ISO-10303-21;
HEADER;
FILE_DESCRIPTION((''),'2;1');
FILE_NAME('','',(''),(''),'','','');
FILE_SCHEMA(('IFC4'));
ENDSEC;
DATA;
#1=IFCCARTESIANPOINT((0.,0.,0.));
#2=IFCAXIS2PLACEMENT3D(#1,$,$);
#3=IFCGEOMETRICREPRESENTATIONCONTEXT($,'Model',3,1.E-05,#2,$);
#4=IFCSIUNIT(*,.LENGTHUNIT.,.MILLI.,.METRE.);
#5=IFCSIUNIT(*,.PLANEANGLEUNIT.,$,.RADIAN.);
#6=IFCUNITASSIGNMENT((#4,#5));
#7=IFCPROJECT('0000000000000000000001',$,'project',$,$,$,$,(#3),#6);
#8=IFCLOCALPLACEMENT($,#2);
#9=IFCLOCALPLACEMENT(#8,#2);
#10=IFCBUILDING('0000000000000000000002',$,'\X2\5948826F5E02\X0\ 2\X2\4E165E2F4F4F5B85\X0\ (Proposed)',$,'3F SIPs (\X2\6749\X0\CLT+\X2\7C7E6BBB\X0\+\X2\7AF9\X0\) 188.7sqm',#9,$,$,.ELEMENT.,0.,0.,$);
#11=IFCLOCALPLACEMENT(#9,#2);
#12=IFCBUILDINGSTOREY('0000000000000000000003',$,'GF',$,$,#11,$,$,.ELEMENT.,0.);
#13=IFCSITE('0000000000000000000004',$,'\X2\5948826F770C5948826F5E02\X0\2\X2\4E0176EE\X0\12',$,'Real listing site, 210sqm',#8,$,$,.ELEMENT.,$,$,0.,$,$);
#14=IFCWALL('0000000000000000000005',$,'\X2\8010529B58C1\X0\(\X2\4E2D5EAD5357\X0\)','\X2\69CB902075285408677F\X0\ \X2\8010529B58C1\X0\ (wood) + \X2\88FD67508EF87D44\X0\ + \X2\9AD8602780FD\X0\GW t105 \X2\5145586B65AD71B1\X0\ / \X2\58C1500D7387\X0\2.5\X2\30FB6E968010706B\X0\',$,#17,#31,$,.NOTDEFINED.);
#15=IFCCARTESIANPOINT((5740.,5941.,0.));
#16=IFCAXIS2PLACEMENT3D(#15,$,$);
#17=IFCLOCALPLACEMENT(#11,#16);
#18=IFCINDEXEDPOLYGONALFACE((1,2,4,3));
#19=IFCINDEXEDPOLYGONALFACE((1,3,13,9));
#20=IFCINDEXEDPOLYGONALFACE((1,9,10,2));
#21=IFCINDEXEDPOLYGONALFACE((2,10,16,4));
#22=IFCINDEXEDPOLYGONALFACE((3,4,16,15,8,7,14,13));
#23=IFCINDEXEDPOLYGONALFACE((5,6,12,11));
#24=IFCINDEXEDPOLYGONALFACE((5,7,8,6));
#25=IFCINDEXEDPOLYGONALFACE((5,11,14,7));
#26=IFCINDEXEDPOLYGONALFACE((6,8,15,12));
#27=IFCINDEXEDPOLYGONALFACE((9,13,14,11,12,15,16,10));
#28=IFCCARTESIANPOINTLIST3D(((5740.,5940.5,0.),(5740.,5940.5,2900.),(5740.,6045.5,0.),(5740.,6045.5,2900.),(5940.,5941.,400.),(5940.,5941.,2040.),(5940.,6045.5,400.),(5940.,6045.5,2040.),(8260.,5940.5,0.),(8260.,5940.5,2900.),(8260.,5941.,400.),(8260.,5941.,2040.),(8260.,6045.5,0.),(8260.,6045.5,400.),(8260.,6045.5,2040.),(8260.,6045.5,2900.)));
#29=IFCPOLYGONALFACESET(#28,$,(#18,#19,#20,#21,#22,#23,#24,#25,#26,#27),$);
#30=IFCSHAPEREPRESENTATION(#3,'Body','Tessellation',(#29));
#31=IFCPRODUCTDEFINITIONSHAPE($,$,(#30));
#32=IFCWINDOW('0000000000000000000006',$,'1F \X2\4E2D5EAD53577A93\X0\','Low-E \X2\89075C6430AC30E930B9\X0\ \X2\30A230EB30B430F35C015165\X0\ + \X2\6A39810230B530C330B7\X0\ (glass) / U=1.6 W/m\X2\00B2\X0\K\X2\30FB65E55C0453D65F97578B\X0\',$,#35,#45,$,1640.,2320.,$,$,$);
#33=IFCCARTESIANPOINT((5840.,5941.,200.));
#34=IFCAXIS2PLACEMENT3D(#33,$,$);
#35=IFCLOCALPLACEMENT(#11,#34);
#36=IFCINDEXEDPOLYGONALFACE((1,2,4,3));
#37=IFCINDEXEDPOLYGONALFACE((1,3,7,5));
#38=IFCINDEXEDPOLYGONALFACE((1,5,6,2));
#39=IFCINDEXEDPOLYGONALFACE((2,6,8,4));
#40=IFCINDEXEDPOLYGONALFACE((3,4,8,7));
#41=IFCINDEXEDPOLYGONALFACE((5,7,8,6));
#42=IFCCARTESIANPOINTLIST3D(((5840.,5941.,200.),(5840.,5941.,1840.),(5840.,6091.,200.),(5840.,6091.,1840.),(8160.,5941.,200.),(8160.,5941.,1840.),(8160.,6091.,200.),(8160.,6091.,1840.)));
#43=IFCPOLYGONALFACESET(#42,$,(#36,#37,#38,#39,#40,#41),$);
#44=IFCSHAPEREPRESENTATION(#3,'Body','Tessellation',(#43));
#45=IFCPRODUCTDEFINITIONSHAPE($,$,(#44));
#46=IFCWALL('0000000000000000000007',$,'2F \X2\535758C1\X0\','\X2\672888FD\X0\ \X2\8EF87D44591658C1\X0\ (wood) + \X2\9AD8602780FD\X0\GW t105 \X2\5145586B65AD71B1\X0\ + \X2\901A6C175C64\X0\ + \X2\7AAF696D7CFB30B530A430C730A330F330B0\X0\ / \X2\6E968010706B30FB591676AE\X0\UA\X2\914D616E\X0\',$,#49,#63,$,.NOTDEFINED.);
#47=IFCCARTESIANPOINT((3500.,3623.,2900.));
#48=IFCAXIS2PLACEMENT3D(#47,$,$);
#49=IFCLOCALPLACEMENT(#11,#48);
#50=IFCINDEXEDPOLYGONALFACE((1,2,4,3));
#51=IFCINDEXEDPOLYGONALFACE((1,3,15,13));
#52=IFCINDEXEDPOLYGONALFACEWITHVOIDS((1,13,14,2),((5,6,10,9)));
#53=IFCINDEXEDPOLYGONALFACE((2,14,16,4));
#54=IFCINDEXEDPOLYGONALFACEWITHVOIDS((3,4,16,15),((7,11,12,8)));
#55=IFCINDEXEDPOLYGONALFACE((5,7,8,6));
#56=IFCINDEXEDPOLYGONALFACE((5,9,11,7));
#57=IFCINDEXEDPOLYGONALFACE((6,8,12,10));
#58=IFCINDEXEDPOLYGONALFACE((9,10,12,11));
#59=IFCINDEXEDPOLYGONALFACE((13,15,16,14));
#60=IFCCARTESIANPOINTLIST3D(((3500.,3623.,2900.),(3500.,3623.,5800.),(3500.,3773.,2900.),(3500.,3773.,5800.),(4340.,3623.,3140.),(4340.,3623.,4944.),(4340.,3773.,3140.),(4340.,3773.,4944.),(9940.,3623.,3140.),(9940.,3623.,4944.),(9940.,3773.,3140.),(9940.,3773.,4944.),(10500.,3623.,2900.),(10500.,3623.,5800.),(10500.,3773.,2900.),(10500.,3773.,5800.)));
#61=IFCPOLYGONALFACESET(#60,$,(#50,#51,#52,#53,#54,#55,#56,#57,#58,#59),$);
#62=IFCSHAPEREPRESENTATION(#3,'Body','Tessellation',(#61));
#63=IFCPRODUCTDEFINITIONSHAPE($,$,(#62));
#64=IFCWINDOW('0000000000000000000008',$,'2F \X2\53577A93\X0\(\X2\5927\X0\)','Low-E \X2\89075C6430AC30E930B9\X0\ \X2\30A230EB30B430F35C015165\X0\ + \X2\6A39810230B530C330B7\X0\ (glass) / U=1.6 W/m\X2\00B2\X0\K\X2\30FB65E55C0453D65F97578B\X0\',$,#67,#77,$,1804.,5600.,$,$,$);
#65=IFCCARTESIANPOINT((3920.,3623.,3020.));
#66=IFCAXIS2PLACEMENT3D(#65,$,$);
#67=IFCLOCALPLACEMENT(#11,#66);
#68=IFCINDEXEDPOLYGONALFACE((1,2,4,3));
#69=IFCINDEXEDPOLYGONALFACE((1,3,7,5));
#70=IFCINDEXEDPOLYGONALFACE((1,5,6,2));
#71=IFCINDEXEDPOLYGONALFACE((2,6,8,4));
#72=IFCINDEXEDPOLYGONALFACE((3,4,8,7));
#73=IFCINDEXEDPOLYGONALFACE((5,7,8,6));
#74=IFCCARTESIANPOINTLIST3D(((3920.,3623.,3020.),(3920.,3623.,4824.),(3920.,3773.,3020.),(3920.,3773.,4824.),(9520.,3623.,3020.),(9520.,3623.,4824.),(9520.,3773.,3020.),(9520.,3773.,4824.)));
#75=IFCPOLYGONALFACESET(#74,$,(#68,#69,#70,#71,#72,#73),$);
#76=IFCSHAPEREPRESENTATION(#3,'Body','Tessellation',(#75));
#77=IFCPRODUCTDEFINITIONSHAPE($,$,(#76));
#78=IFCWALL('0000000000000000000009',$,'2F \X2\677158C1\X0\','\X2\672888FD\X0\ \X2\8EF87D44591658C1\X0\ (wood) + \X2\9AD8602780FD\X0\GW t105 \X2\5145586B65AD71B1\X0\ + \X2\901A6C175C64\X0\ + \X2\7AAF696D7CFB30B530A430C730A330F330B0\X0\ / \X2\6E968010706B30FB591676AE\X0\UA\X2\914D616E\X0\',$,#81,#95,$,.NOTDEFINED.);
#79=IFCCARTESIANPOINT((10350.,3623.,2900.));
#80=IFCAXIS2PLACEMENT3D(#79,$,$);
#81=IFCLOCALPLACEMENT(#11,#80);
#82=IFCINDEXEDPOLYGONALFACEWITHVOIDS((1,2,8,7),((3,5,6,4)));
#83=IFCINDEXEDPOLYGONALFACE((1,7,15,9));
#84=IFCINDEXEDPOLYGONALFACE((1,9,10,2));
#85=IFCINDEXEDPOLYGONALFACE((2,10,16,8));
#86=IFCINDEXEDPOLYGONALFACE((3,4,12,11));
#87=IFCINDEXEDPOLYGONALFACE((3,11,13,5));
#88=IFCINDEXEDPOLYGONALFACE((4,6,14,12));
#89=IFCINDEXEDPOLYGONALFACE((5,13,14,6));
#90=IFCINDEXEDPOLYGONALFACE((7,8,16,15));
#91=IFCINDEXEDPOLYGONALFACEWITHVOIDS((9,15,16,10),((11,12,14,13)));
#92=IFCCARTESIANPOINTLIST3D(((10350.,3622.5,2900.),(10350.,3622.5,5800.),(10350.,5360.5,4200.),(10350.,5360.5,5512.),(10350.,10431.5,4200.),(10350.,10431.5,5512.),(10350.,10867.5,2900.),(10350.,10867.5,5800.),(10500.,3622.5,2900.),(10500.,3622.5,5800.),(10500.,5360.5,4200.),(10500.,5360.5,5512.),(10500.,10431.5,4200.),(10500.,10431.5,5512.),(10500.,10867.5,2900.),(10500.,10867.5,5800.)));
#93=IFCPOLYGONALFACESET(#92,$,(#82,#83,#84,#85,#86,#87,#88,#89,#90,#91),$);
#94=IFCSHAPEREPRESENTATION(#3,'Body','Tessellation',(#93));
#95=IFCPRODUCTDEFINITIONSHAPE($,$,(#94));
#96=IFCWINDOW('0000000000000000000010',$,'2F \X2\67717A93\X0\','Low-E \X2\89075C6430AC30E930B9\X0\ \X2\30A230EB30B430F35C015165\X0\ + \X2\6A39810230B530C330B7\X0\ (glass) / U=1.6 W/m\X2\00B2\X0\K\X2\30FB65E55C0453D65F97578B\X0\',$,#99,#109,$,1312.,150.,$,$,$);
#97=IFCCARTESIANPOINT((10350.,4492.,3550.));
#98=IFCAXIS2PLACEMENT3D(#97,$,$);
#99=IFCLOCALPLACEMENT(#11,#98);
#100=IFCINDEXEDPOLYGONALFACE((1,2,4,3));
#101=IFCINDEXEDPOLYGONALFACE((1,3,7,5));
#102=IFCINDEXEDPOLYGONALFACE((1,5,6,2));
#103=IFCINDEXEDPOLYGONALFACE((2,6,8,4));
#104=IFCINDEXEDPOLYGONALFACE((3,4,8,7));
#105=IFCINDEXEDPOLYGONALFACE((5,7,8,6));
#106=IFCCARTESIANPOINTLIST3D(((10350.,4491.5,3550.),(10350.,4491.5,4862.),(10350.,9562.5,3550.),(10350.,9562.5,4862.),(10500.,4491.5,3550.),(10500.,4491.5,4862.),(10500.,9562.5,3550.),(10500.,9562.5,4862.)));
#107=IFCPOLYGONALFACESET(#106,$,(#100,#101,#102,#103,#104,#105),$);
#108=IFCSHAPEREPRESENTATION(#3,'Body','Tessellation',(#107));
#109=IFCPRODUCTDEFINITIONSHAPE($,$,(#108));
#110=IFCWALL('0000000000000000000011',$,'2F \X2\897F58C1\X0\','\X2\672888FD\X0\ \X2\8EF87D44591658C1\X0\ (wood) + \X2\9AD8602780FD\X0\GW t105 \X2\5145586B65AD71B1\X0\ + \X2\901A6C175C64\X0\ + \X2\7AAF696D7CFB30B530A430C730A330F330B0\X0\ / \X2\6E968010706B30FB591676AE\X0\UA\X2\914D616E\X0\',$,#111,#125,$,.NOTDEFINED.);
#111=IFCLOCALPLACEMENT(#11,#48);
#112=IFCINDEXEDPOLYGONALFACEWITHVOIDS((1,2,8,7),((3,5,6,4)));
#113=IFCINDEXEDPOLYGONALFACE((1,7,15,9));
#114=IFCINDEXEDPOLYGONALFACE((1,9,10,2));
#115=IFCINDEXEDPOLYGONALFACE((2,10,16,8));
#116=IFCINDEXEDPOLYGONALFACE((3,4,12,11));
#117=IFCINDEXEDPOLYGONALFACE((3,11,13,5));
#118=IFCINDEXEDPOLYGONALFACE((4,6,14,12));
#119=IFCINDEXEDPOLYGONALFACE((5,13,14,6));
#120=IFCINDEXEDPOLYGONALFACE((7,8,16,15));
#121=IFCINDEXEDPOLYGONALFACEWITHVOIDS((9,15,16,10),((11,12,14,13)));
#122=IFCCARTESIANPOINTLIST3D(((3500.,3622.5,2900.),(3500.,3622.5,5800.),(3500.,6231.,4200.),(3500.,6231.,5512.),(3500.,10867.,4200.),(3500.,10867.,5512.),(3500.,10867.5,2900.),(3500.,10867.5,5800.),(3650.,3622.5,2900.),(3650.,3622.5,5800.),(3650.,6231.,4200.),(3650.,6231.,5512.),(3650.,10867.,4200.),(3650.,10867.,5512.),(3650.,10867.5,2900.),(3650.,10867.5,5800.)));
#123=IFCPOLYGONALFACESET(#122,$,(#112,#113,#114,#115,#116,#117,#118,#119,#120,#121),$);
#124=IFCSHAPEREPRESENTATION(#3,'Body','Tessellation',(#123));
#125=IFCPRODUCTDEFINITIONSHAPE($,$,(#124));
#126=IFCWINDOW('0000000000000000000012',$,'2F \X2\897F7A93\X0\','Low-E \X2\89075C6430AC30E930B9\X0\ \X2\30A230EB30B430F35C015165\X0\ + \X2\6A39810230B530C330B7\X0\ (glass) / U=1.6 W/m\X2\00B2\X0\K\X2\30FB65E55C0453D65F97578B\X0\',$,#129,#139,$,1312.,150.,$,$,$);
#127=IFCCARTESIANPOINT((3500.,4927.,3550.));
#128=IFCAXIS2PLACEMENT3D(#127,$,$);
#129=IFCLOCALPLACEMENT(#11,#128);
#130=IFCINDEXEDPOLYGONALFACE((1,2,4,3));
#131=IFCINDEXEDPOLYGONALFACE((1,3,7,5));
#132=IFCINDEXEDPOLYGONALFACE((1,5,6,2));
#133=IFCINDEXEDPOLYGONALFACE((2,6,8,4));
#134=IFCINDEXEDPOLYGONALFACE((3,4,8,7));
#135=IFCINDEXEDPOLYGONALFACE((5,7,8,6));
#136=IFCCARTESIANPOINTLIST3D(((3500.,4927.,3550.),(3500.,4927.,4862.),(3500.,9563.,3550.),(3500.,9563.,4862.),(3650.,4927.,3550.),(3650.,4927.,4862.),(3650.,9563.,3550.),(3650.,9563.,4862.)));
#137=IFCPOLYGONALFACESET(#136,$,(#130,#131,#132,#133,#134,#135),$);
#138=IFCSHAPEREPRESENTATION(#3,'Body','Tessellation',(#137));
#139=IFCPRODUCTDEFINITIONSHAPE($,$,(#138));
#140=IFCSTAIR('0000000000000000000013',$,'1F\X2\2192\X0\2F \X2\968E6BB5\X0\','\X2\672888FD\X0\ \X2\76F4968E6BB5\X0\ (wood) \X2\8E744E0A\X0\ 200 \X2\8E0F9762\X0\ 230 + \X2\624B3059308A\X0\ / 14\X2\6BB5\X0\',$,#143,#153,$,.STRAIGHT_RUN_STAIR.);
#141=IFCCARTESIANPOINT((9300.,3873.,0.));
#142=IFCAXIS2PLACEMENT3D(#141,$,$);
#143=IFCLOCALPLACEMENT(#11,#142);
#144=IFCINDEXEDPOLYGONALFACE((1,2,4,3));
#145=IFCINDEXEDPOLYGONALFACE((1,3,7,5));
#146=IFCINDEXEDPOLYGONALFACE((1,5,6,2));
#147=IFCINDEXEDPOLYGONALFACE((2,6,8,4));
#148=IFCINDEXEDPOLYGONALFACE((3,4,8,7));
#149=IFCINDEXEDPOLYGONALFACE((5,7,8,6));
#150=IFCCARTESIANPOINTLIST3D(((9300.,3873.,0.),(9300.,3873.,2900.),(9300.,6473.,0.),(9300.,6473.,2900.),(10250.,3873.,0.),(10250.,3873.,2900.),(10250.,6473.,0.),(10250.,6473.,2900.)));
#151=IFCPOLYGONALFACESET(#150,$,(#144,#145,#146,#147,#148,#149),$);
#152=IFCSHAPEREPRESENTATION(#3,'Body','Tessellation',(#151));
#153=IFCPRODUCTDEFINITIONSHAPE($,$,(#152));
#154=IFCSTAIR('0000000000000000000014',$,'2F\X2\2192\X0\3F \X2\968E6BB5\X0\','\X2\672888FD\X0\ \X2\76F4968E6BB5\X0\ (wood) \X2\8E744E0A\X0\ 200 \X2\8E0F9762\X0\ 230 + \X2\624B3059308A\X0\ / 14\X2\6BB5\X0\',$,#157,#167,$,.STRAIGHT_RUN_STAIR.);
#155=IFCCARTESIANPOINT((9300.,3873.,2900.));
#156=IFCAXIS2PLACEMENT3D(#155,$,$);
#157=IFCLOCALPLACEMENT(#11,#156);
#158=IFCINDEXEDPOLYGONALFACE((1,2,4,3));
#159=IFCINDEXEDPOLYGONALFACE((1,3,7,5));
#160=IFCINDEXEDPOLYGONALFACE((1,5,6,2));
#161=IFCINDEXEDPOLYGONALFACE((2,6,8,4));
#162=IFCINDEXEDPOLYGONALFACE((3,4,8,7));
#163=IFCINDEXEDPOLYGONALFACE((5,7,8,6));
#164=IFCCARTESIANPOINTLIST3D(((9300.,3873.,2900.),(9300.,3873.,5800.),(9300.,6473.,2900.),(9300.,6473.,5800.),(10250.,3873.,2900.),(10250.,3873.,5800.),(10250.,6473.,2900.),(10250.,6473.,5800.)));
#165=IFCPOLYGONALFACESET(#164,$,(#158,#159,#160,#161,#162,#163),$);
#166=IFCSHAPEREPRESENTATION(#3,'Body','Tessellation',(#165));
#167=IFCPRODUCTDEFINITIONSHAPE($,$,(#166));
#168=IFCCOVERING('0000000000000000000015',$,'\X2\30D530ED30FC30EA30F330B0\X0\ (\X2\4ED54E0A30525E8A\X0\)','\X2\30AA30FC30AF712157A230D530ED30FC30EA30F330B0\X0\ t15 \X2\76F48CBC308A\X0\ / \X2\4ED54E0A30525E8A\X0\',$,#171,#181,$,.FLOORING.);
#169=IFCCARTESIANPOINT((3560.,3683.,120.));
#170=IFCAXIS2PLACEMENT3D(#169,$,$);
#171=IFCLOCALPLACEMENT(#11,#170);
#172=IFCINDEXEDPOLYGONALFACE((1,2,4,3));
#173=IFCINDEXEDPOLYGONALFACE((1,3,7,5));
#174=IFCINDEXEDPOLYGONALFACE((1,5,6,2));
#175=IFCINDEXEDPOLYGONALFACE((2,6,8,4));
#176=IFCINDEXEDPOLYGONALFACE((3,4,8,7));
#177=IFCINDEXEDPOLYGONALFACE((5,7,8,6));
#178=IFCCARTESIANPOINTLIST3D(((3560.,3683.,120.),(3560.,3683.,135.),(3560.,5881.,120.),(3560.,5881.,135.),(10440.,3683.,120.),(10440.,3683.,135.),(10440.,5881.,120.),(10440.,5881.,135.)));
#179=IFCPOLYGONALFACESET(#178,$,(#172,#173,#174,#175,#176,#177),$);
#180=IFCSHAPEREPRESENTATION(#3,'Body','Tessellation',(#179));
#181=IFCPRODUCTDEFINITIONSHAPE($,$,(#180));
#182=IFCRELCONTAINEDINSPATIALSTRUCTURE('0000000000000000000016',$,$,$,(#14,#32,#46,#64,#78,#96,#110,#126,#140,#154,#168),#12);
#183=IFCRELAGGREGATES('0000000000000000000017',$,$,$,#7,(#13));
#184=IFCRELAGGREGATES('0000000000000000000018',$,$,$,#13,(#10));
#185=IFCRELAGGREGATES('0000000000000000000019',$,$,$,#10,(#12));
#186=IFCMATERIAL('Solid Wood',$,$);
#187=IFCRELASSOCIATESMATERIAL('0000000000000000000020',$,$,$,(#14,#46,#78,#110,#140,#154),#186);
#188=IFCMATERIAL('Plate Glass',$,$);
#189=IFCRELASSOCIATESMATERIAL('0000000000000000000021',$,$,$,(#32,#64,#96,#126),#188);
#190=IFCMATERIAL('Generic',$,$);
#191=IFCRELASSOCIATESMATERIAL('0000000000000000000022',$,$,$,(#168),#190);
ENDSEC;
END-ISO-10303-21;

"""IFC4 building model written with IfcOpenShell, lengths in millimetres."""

from ifc_helpers import new_model, si_unit, frame, frame_2d, origin, place, context, project, spatial, rectangle, extrude, material, element, fill, save


model = new_model("IFC4")

# Units and contexts
model_context = context("Model", 3, precision=1e-05, world=origin())
ifc_project = project(units=[si_unit("LENGTHUNIT", "METRE", prefix="MILLI"), si_unit("PLANEANGLEUNIT", "RADIAN")], contexts=[model_context])

# Site, building, storey
site_placement = place(None, origin())
site = spatial("IfcSite", under=ifc_project, at=site_placement, Name="奈良県奈良市2丁目12", ObjectType="Real listing site, 210sqm", CompositionType="ELEMENT", RefElevation=0.0)
building_placement = place(site_placement, origin())
building = spatial("IfcBuilding", under=site, at=building_placement, Name="奈良市 2世帯住宅 (Proposed)", ObjectType="3F SIPs (杉CLT+籾殻+竹) 188.7sqm", CompositionType="ELEMENT", ElevationOfRefHeight=0.0, ElevationOfTerrain=0.0)
storey_placement = place(building_placement, origin())
storey = spatial("IfcBuildingStorey", under=building, at=storey_placement, Name="GF", CompositionType="ELEMENT", Elevation=0.0)

# Shared definitions
ifc_material_1 = material(Name="Solid Wood")

# Shared definitions
ifc_material_2 = material(Name="Plate Glass")

# Walls, openings, windows
wall_1_placement = place(storey_placement, frame((5740.0, 5941.0, 0.0)))
wall_1 = element("IfcWall", 1, at=wall_1_placement, inside=storey, material=ifc_material_1, Name="耐力壁(中庭南)", Description="構造用合板 耐力壁 (wood) + 製材軸組 + 高性能GW t105 充填断熱 / 壁倍率2.5・準耐火", PredefinedType="NOTDEFINED", context=model_context, shape_type="SweptSolid", body=[
    extrude(rectangle(XDim=2520.0, YDim=105.0, at=frame_2d((1260.0, 52.0))), frame((5740.0, 5941.0, 0.0)), (0.0, 0.0, 1.0), 2900.0),
])
opening_1_placement = place(storey_placement, frame((5840.0, 5941.0, 200.0)))
opening_1 = element("IfcOpeningElement", 2, at=opening_1_placement, cuts=wall_1, PredefinedType="NOTDEFINED", context=model_context, shape_type="SweptSolid", body=[
    extrude(rectangle(XDim=2320.0, YDim=150.0, at=frame_2d((1160.0, 75.0))), frame((5840.0, 5941.0, 200.0)), (0.0, 0.0, 1.0), 1640.0),
])
window_1_placement = place(storey_placement, frame((5840.0, 5941.0, 200.0)))
window_1 = element("IfcWindow", 3, at=window_1_placement, inside=storey, material=ifc_material_2, Name="1F 中庭南窓", Description="Low-E 複層ガラス アルゴン封入 + 樹脂サッシ (glass) / U=1.6 W/m²K・日射取得型", OverallHeight=1640.0, OverallWidth=2320.0, context=model_context, shape_type="SweptSolid", body=[
    extrude(rectangle(XDim=2320.0, YDim=150.0, at=frame_2d((1160.0, 75.0))), frame((5840.0, 5941.0, 200.0)), (0.0, 0.0, 1.0), 1640.0),
])
fill(opening_1, window_1)
wall_2_placement = place(storey_placement, frame((3500.0, 3623.0, 2900.0)))
wall_2 = element("IfcWall", 4, at=wall_2_placement, inside=storey, material=ifc_material_1, Name="2F 南壁", Description="木製 軸組外壁 (wood) + 高性能GW t105 充填断熱 + 通気層 + 窯業系サイディング / 準耐火・外皮UA配慮", PredefinedType="NOTDEFINED", context=model_context, shape_type="SweptSolid", body=[
    extrude(rectangle(XDim=7000.0, YDim=150.0, at=frame_2d((3500.0, 75.0))), frame((3500.0, 3623.0, 2900.0)), (0.0, 0.0, 1.0), 2900.0),
])
opening_2_placement = place(storey_placement, frame((3920.0, 3623.0, 3020.0)))
opening_2 = element("IfcOpeningElement", 5, at=opening_2_placement, cuts=wall_2, PredefinedType="NOTDEFINED", context=model_context, shape_type="SweptSolid", body=[
    extrude(rectangle(XDim=5600.0, YDim=150.0, at=frame_2d((2800.0, 75.0))), frame((3920.0, 3623.0, 3020.0)), (0.0, 0.0, 1.0), 1804.0),
])
window_2_placement = place(storey_placement, frame((3920.0, 3623.0, 3020.0)))
window_2 = element("IfcWindow", 6, at=window_2_placement, inside=storey, material=ifc_material_2, Name="2F 南窓(大)", Description="Low-E 複層ガラス アルゴン封入 + 樹脂サッシ (glass) / U=1.6 W/m²K・日射取得型", OverallHeight=1804.0, OverallWidth=5600.0, context=model_context, shape_type="SweptSolid", body=[
    extrude(rectangle(XDim=5600.0, YDim=150.0, at=frame_2d((2800.0, 75.0))), frame((3920.0, 3623.0, 3020.0)), (0.0, 0.0, 1.0), 1804.0),
])
fill(opening_2, window_2)
wall_3_placement = place(storey_placement, frame((10350.0, 3623.0, 2900.0)))
wall_3 = element("IfcWall", 7, at=wall_3_placement, inside=storey, material=ifc_material_1, Name="2F 東壁", Description="木製 軸組外壁 (wood) + 高性能GW t105 充填断熱 + 通気層 + 窯業系サイディング / 準耐火・外皮UA配慮", PredefinedType="NOTDEFINED", context=model_context, shape_type="SweptSolid", body=[
    extrude(rectangle(XDim=150.0, YDim=7245.0, at=frame_2d((75.0, 3622.0))), frame((10350.0, 3623.0, 2900.0)), (0.0, 0.0, 1.0), 2900.0),
])
opening_3_placement = place(storey_placement, frame((10350.0, 4492.0, 3550.0)))
opening_3 = element("IfcOpeningElement", 8, at=opening_3_placement, cuts=wall_3, PredefinedType="NOTDEFINED", context=model_context, shape_type="SweptSolid", body=[
    extrude(rectangle(XDim=150.0, YDim=5071.0, at=frame_2d((75.0, 2535.0))), frame((10350.0, 4492.0, 3550.0)), (0.0, 0.0, 1.0), 1312.0),
])
window_3_placement = place(storey_placement, frame((10350.0, 4492.0, 3550.0)))
window_3 = element("IfcWindow", 9, at=window_3_placement, inside=storey, material=ifc_material_2, Name="2F 東窓", Description="Low-E 複層ガラス アルゴン封入 + 樹脂サッシ (glass) / U=1.6 W/m²K・日射取得型", OverallHeight=1312.0, OverallWidth=150.0, context=model_context, shape_type="SweptSolid", body=[
    extrude(rectangle(XDim=150.0, YDim=5071.0, at=frame_2d((75.0, 2535.0))), frame((10350.0, 4492.0, 3550.0)), (0.0, 0.0, 1.0), 1312.0),
])
fill(opening_3, window_3)
wall_4_placement = place(storey_placement, frame((3500.0, 3623.0, 2900.0)))
wall_4 = element("IfcWall", 10, at=wall_4_placement, inside=storey, material=ifc_material_1, Name="2F 西壁", Description="木製 軸組外壁 (wood) + 高性能GW t105 充填断熱 + 通気層 + 窯業系サイディング / 準耐火・外皮UA配慮", PredefinedType="NOTDEFINED", context=model_context, shape_type="SweptSolid", body=[
    extrude(rectangle(XDim=150.0, YDim=7245.0, at=frame_2d((75.0, 3622.0))), frame((3500.0, 3623.0, 2900.0)), (0.0, 0.0, 1.0), 2900.0),
])
opening_4_placement = place(storey_placement, frame((3500.0, 4927.0, 3550.0)))
opening_4 = element("IfcOpeningElement", 11, at=opening_4_placement, cuts=wall_4, PredefinedType="NOTDEFINED", context=model_context, shape_type="SweptSolid", body=[
    extrude(rectangle(XDim=150.0, YDim=4636.0, at=frame_2d((75.0, 2318.0))), frame((3500.0, 4927.0, 3550.0)), (0.0, 0.0, 1.0), 1312.0),
])
window_4_placement = place(storey_placement, frame((3500.0, 4927.0, 3550.0)))
window_4 = element("IfcWindow", 12, at=window_4_placement, inside=storey, material=ifc_material_2, Name="2F 西窓", Description="Low-E 複層ガラス アルゴン封入 + 樹脂サッシ (glass) / U=1.6 W/m²K・日射取得型", OverallHeight=1312.0, OverallWidth=150.0, context=model_context, shape_type="SweptSolid", body=[
    extrude(rectangle(XDim=150.0, YDim=4636.0, at=frame_2d((75.0, 2318.0))), frame((3500.0, 4927.0, 3550.0)), (0.0, 0.0, 1.0), 1312.0),
])
fill(opening_4, window_4)

# Stairs
stair_1_placement = place(storey_placement, frame((9300.0, 3873.0, 0.0)))
element("IfcStair", 13, at=stair_1_placement, inside=storey, material=ifc_material_1, Name="1F→2F 階段", Description="木製 直階段 (wood) 蹴上 200 踏面 230 + 手すり / 14段", PredefinedType="STRAIGHT_RUN_STAIR", context=model_context, shape_type="SweptSolid", body=[
    extrude(rectangle(XDim=950.0, YDim=2600.0, at=frame_2d((475.0, 1300.0))), frame((9300.0, 3873.0, 0.0)), (0.0, 0.0, 1.0), 2900.0),
])
stair_2_placement = place(storey_placement, frame((9300.0, 3873.0, 2900.0)))
element("IfcStair", 14, at=stair_2_placement, inside=storey, material=ifc_material_1, Name="2F→3F 階段", Description="木製 直階段 (wood) 蹴上 200 踏面 230 + 手すり / 14段", PredefinedType="STRAIGHT_RUN_STAIR", context=model_context, shape_type="SweptSolid", body=[
    extrude(rectangle(XDim=950.0, YDim=2600.0, at=frame_2d((475.0, 1300.0))), frame((9300.0, 3873.0, 2900.0)), (0.0, 0.0, 1.0), 2900.0),
])

# Covering
ifc_material_3 = material(Name="Generic")
covering_placement = place(storey_placement, frame((3560.0, 3683.0, 120.0)))
element("IfcCovering", 15, at=covering_placement, inside=storey, material=ifc_material_3, Name="フローリング (仕上げ床)", Description="オーク無垢フローリング t15 直貼り / 仕上げ床", PredefinedType="FLOORING", context=model_context, shape_type="SweptSolid", body=[
    extrude(rectangle(XDim=6880.0, YDim=2198.0, at=frame_2d((3440.0, 1099.0))), frame((3560.0, 3683.0, 120.0)), (0.0, 0.0, 1.0), 15.0),
])

save(model, "model.ifc")
